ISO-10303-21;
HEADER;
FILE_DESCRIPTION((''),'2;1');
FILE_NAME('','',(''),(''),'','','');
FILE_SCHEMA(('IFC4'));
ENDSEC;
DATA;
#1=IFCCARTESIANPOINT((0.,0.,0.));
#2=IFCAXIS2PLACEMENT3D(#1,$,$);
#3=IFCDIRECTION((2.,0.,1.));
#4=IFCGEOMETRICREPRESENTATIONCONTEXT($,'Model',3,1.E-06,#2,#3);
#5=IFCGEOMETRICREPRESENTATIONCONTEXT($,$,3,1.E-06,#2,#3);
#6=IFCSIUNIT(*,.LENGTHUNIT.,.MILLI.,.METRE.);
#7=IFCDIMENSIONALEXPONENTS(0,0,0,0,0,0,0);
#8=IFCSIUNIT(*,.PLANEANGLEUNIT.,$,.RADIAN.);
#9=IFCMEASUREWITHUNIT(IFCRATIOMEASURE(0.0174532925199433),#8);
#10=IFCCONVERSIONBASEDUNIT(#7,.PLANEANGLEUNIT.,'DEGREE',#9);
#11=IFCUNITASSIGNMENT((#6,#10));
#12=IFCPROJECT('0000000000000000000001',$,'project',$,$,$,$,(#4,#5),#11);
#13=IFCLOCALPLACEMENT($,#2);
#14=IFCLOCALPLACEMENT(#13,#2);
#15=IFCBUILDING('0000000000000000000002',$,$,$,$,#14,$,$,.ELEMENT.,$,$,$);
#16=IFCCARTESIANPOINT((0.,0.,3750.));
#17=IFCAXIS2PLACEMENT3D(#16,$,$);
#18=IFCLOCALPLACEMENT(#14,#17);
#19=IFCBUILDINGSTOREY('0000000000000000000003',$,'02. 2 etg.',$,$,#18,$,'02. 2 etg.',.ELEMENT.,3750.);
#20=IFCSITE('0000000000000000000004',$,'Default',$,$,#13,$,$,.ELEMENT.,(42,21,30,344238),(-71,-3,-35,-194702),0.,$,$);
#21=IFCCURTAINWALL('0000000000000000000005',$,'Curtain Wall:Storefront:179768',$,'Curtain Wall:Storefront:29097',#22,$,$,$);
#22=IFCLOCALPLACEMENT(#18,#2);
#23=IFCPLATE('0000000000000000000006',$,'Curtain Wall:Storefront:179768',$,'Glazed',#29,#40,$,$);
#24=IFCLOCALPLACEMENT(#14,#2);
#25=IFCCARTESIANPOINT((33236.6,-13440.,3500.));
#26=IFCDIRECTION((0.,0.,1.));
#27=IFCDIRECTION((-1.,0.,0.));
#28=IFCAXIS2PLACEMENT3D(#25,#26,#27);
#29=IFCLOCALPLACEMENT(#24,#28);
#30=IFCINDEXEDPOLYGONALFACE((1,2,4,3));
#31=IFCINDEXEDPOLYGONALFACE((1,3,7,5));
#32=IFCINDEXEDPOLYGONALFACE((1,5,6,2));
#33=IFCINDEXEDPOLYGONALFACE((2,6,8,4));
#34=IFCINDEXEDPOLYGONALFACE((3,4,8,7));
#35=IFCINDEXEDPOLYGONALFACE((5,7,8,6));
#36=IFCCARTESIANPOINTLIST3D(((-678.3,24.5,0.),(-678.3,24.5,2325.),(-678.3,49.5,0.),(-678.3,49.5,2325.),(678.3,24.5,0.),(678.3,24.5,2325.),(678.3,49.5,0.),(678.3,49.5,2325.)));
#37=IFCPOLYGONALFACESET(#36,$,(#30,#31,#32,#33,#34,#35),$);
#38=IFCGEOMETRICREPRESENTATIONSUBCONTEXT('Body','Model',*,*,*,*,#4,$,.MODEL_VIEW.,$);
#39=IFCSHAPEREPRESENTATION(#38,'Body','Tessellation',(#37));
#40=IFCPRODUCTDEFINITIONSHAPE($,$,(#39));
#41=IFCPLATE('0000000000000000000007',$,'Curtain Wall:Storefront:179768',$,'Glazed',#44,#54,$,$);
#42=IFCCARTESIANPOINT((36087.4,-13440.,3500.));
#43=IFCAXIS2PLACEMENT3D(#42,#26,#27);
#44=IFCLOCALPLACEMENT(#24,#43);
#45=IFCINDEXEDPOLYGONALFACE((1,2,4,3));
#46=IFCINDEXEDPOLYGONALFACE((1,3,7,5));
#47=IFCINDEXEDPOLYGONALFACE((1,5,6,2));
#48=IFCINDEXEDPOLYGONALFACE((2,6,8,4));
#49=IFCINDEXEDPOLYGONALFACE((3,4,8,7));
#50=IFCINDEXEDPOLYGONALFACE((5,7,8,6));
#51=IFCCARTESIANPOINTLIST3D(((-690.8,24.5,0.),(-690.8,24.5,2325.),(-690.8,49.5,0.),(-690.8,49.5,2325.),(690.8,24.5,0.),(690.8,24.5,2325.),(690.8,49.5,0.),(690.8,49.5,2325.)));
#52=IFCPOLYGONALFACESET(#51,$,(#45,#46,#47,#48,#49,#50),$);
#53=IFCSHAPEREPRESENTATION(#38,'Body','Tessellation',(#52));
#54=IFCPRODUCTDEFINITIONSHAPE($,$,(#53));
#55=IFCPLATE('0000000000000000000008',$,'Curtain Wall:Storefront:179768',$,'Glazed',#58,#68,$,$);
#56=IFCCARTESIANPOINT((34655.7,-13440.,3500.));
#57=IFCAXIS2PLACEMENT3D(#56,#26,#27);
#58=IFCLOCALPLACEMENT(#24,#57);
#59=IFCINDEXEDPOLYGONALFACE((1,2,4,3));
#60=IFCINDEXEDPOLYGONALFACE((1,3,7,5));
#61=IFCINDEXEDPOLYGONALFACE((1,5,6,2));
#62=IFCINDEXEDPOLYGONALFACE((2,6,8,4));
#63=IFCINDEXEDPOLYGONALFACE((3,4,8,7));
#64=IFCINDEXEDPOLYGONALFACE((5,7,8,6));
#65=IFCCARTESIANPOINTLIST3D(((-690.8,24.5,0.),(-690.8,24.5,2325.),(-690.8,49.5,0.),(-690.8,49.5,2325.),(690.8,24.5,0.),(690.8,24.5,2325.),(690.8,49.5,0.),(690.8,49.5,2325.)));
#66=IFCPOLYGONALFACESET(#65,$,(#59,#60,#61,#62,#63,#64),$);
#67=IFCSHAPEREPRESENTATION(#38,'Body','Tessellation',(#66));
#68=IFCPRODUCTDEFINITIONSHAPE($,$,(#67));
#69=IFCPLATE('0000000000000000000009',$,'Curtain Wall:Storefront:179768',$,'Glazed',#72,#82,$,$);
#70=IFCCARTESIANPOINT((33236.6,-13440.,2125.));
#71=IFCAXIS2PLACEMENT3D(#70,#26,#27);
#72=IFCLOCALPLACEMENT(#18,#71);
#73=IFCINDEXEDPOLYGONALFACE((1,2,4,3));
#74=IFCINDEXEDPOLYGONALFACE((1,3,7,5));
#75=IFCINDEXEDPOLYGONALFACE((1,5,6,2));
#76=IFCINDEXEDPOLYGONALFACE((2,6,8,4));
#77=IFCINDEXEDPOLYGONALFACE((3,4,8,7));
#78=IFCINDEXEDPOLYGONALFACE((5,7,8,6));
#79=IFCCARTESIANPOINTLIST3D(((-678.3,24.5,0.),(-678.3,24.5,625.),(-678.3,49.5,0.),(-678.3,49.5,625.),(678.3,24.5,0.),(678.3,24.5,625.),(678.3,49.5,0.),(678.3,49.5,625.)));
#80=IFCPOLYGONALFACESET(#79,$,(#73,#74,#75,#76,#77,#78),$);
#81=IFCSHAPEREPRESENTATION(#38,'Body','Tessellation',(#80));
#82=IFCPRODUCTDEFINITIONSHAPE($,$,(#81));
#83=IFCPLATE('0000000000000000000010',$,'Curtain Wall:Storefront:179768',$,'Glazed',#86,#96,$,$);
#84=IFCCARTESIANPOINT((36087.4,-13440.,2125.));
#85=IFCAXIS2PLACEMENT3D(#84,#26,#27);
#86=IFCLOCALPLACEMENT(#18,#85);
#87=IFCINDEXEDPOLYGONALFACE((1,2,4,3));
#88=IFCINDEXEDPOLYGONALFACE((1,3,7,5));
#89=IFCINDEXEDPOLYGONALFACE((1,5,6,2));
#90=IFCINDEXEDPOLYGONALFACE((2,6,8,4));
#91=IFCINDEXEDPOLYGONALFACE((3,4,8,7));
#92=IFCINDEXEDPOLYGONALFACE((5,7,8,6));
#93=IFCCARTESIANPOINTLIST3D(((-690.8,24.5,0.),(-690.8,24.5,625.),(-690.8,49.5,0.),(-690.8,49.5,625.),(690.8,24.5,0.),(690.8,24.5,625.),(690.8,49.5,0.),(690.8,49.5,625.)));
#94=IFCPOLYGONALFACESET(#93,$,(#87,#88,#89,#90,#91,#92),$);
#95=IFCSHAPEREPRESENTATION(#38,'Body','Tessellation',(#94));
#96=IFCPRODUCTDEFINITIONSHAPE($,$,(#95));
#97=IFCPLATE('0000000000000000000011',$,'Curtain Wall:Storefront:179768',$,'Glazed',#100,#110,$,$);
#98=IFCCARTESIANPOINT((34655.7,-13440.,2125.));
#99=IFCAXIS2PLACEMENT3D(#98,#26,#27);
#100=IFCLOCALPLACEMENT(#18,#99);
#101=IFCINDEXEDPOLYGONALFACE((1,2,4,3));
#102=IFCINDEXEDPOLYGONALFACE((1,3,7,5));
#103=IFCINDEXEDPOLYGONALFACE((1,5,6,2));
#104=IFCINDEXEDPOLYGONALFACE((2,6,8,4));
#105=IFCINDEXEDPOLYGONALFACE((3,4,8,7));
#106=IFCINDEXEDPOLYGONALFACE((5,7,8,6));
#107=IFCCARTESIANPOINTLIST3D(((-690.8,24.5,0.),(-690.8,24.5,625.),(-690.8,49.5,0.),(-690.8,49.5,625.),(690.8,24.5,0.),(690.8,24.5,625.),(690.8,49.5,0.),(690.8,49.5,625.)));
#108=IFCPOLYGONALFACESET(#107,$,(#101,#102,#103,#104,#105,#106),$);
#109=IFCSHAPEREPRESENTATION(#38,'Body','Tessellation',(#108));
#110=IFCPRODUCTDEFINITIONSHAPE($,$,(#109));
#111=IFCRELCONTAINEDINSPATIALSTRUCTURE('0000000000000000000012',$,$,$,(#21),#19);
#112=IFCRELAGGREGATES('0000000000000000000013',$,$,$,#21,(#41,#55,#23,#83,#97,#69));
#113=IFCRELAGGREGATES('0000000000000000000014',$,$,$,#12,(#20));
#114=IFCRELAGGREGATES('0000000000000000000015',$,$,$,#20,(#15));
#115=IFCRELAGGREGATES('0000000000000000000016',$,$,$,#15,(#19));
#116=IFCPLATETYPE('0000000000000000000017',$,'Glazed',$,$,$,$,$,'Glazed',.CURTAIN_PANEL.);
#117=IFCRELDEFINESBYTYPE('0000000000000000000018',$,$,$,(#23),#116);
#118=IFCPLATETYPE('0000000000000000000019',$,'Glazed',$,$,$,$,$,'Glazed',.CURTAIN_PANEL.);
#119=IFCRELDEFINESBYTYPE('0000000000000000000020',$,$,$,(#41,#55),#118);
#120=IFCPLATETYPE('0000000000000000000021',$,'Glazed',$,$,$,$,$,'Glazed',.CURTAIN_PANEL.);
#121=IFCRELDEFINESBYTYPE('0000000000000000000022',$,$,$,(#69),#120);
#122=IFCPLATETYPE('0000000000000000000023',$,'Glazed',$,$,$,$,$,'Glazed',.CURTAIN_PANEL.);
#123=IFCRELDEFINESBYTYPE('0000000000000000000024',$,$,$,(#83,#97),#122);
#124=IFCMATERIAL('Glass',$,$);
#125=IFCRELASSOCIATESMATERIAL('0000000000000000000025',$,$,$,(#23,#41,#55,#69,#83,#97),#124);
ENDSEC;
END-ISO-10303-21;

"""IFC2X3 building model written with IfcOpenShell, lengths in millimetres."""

from ifc_helpers import new_model, entity, si_unit, converted_unit, direction, frame, origin, origin_2d_with_axis, place, context, subcontext, project, spatial, rectangle, extrude, source, transform, mapped, material, type_object, type_shapes, element, aggregate, save


model = new_model("IFC2X3")

# Units and contexts
model_context = context("Model", 3, precision=1e-06, world=origin(), true_north=direction((2.0, 0.0, 1.0)))
context_of_model = context(None, 3, precision=1e-06, world=origin(), true_north=direction((2.0, 0.0, 1.0)))
body_context = subcontext(model_context, "Body", "Model", "MODEL_VIEW")
ifc_project = project(units=[si_unit("LENGTHUNIT", "METRE", prefix="MILLI"), converted_unit("PLANEANGLEUNIT", "DEGREE", entity("IfcRatioMeasure", 0.0174532925199433), si_unit("PLANEANGLEUNIT", "RADIAN"), dimensions=[0, 0, 0, 0, 0, 0, 0])], contexts=[model_context, context_of_model])

# Site, building, storey
site_placement = place(None, origin())
site = spatial("IfcSite", under=ifc_project, at=site_placement, Name="Default", CompositionType="ELEMENT", RefLatitude=(42, 21, 30, 344238), RefLongitude=(-71, -3, -35, -194702), RefElevation=0.0)
building_placement = place(site_placement, origin())
building = spatial("IfcBuilding", under=site, at=building_placement, CompositionType="ELEMENT")
storey_placement = place(building_placement, frame((0.0, 0.0, 3750.0)))
storey = spatial("IfcBuildingStorey", under=building, at=storey_placement, Name="02. 2 etg.", LongName="02. 2 etg.", CompositionType="ELEMENT", Elevation=3750.0)

# Curtain wall, plates
curtain_wall_placement = place(storey_placement, origin())
curtain_wall = element("IfcCurtainWall", 1, at=curtain_wall_placement, inside=storey, Name="Curtain Wall:Storefront:179768", ObjectType="Curtain Wall:Storefront:29097")
ifc_material_1 = material(Name="Glass")
plate_type_1 = type_object("IfcPlateType", Name="Glazed", ElementType="Glazed", PredefinedType="CURTAIN_PANEL")
shared_shape_1 = source(origin(), body_context, "Body", "SweptSolid", [
    extrude(rectangle(XDim=25.0, YDim=1356.7, at=origin_2d_with_axis()), frame((0.0, 37.0, 0.0), z_axis=(0.0, 0.0, 1.0), x_axis=(0.0, 1.0, 0.0)), (0.0, 0.0, 1.0), 2325.0),
])
type_shapes(plate_type_1, [shared_shape_1])
placement = place(building_placement, origin())
plate_1_placement = place(placement, frame((33236.6, -13440.0, 3500.0), z_axis=(0.0, 0.0, 1.0), x_axis=(-1.0, 0.0, 0.0)))
plate_1 = element("IfcPlate", 2, at=plate_1_placement, type_object=plate_type_1, material=ifc_material_1, Name="Curtain Wall:Storefront:179768", ObjectType="Glazed", context=body_context, shape_type="MappedRepresentation", body=[
    mapped(shared_shape_1, transform((0.0, 0.0, 0.0), scale=1.0)),
])
plate_type_2 = type_object("IfcPlateType", Name="Glazed", ElementType="Glazed", PredefinedType="CURTAIN_PANEL")
shared_shape_2 = source(origin(), body_context, "Body", "SweptSolid", [
    extrude(rectangle(XDim=25.0, YDim=1381.7, at=origin_2d_with_axis()), frame((0.0, 37.0, 0.0), z_axis=(0.0, 0.0, 1.0), x_axis=(0.0, 1.0, 0.0)), (0.0, 0.0, 1.0), 2325.0),
])
type_shapes(plate_type_2, [shared_shape_2])
plate_2_placement = place(placement, frame((36087.4, -13440.0, 3500.0), z_axis=(0.0, 0.0, 1.0), x_axis=(-1.0, 0.0, 0.0)))
plate_2 = element("IfcPlate", 3, at=plate_2_placement, type_object=plate_type_2, material=ifc_material_1, Name="Curtain Wall:Storefront:179768", ObjectType="Glazed", context=body_context, shape_type="MappedRepresentation", body=[
    mapped(shared_shape_2, transform((0.0, 0.0, 0.0), scale=1.0)),
])
plate_3_placement = place(placement, frame((34655.7, -13440.0, 3500.0), z_axis=(0.0, 0.0, 1.0), x_axis=(-1.0, 0.0, 0.0)))
plate_3 = element("IfcPlate", 4, at=plate_3_placement, type_object=plate_type_2, material=ifc_material_1, Name="Curtain Wall:Storefront:179768", ObjectType="Glazed", context=body_context, shape_type="MappedRepresentation", body=[
    mapped(shared_shape_2, transform((0.0, 0.0, 0.0), scale=1.0)),
])
plate_type_3 = type_object("IfcPlateType", Name="Glazed", ElementType="Glazed", PredefinedType="CURTAIN_PANEL")
shared_shape_3 = source(origin(), body_context, "Body", "SweptSolid", [
    extrude(rectangle(XDim=25.0, YDim=1356.7, at=origin_2d_with_axis()), frame((0.0, 37.0, 0.0), z_axis=(0.0, 0.0, 1.0), x_axis=(0.0, 1.0, 0.0)), (0.0, 0.0, 1.0), 625.0),
])
type_shapes(plate_type_3, [shared_shape_3])
plate_4_placement = place(storey_placement, frame((33236.6, -13440.0, 2125.0), z_axis=(0.0, 0.0, 1.0), x_axis=(-1.0, 0.0, 0.0)))
plate_4 = element("IfcPlate", 5, at=plate_4_placement, type_object=plate_type_3, material=ifc_material_1, Name="Curtain Wall:Storefront:179768", ObjectType="Glazed", context=body_context, shape_type="MappedRepresentation", body=[
    mapped(shared_shape_3, transform((0.0, 0.0, 0.0), scale=1.0)),
])
plate_type_4 = type_object("IfcPlateType", Name="Glazed", ElementType="Glazed", PredefinedType="CURTAIN_PANEL")
shared_shape_4 = source(origin(), body_context, "Body", "SweptSolid", [
    extrude(rectangle(XDim=25.0, YDim=1381.7, at=origin_2d_with_axis()), frame((0.0, 37.0, 0.0), z_axis=(0.0, 0.0, 1.0), x_axis=(0.0, 1.0, 0.0)), (0.0, 0.0, 1.0), 625.0),
])
type_shapes(plate_type_4, [shared_shape_4])
plate_5_placement = place(storey_placement, frame((36087.4, -13440.0, 2125.0), z_axis=(0.0, 0.0, 1.0), x_axis=(-1.0, 0.0, 0.0)))
plate_5 = element("IfcPlate", 6, at=plate_5_placement, type_object=plate_type_4, material=ifc_material_1, Name="Curtain Wall:Storefront:179768", ObjectType="Glazed", context=body_context, shape_type="MappedRepresentation", body=[
    mapped(shared_shape_4, transform((0.0, 0.0, 0.0), scale=1.0)),
])
plate_6_placement = place(storey_placement, frame((34655.7, -13440.0, 2125.0), z_axis=(0.0, 0.0, 1.0), x_axis=(-1.0, 0.0, 0.0)))
plate_6 = element("IfcPlate", 7, at=plate_6_placement, type_object=plate_type_4, material=ifc_material_1, Name="Curtain Wall:Storefront:179768", ObjectType="Glazed", context=body_context, shape_type="MappedRepresentation", body=[
    mapped(shared_shape_4, transform((0.0, 0.0, 0.0), scale=1.0)),
])
aggregate(curtain_wall, [plate_2, plate_3, plate_1, plate_5, plate_6, plate_4])

save(model, "model.ifc")
